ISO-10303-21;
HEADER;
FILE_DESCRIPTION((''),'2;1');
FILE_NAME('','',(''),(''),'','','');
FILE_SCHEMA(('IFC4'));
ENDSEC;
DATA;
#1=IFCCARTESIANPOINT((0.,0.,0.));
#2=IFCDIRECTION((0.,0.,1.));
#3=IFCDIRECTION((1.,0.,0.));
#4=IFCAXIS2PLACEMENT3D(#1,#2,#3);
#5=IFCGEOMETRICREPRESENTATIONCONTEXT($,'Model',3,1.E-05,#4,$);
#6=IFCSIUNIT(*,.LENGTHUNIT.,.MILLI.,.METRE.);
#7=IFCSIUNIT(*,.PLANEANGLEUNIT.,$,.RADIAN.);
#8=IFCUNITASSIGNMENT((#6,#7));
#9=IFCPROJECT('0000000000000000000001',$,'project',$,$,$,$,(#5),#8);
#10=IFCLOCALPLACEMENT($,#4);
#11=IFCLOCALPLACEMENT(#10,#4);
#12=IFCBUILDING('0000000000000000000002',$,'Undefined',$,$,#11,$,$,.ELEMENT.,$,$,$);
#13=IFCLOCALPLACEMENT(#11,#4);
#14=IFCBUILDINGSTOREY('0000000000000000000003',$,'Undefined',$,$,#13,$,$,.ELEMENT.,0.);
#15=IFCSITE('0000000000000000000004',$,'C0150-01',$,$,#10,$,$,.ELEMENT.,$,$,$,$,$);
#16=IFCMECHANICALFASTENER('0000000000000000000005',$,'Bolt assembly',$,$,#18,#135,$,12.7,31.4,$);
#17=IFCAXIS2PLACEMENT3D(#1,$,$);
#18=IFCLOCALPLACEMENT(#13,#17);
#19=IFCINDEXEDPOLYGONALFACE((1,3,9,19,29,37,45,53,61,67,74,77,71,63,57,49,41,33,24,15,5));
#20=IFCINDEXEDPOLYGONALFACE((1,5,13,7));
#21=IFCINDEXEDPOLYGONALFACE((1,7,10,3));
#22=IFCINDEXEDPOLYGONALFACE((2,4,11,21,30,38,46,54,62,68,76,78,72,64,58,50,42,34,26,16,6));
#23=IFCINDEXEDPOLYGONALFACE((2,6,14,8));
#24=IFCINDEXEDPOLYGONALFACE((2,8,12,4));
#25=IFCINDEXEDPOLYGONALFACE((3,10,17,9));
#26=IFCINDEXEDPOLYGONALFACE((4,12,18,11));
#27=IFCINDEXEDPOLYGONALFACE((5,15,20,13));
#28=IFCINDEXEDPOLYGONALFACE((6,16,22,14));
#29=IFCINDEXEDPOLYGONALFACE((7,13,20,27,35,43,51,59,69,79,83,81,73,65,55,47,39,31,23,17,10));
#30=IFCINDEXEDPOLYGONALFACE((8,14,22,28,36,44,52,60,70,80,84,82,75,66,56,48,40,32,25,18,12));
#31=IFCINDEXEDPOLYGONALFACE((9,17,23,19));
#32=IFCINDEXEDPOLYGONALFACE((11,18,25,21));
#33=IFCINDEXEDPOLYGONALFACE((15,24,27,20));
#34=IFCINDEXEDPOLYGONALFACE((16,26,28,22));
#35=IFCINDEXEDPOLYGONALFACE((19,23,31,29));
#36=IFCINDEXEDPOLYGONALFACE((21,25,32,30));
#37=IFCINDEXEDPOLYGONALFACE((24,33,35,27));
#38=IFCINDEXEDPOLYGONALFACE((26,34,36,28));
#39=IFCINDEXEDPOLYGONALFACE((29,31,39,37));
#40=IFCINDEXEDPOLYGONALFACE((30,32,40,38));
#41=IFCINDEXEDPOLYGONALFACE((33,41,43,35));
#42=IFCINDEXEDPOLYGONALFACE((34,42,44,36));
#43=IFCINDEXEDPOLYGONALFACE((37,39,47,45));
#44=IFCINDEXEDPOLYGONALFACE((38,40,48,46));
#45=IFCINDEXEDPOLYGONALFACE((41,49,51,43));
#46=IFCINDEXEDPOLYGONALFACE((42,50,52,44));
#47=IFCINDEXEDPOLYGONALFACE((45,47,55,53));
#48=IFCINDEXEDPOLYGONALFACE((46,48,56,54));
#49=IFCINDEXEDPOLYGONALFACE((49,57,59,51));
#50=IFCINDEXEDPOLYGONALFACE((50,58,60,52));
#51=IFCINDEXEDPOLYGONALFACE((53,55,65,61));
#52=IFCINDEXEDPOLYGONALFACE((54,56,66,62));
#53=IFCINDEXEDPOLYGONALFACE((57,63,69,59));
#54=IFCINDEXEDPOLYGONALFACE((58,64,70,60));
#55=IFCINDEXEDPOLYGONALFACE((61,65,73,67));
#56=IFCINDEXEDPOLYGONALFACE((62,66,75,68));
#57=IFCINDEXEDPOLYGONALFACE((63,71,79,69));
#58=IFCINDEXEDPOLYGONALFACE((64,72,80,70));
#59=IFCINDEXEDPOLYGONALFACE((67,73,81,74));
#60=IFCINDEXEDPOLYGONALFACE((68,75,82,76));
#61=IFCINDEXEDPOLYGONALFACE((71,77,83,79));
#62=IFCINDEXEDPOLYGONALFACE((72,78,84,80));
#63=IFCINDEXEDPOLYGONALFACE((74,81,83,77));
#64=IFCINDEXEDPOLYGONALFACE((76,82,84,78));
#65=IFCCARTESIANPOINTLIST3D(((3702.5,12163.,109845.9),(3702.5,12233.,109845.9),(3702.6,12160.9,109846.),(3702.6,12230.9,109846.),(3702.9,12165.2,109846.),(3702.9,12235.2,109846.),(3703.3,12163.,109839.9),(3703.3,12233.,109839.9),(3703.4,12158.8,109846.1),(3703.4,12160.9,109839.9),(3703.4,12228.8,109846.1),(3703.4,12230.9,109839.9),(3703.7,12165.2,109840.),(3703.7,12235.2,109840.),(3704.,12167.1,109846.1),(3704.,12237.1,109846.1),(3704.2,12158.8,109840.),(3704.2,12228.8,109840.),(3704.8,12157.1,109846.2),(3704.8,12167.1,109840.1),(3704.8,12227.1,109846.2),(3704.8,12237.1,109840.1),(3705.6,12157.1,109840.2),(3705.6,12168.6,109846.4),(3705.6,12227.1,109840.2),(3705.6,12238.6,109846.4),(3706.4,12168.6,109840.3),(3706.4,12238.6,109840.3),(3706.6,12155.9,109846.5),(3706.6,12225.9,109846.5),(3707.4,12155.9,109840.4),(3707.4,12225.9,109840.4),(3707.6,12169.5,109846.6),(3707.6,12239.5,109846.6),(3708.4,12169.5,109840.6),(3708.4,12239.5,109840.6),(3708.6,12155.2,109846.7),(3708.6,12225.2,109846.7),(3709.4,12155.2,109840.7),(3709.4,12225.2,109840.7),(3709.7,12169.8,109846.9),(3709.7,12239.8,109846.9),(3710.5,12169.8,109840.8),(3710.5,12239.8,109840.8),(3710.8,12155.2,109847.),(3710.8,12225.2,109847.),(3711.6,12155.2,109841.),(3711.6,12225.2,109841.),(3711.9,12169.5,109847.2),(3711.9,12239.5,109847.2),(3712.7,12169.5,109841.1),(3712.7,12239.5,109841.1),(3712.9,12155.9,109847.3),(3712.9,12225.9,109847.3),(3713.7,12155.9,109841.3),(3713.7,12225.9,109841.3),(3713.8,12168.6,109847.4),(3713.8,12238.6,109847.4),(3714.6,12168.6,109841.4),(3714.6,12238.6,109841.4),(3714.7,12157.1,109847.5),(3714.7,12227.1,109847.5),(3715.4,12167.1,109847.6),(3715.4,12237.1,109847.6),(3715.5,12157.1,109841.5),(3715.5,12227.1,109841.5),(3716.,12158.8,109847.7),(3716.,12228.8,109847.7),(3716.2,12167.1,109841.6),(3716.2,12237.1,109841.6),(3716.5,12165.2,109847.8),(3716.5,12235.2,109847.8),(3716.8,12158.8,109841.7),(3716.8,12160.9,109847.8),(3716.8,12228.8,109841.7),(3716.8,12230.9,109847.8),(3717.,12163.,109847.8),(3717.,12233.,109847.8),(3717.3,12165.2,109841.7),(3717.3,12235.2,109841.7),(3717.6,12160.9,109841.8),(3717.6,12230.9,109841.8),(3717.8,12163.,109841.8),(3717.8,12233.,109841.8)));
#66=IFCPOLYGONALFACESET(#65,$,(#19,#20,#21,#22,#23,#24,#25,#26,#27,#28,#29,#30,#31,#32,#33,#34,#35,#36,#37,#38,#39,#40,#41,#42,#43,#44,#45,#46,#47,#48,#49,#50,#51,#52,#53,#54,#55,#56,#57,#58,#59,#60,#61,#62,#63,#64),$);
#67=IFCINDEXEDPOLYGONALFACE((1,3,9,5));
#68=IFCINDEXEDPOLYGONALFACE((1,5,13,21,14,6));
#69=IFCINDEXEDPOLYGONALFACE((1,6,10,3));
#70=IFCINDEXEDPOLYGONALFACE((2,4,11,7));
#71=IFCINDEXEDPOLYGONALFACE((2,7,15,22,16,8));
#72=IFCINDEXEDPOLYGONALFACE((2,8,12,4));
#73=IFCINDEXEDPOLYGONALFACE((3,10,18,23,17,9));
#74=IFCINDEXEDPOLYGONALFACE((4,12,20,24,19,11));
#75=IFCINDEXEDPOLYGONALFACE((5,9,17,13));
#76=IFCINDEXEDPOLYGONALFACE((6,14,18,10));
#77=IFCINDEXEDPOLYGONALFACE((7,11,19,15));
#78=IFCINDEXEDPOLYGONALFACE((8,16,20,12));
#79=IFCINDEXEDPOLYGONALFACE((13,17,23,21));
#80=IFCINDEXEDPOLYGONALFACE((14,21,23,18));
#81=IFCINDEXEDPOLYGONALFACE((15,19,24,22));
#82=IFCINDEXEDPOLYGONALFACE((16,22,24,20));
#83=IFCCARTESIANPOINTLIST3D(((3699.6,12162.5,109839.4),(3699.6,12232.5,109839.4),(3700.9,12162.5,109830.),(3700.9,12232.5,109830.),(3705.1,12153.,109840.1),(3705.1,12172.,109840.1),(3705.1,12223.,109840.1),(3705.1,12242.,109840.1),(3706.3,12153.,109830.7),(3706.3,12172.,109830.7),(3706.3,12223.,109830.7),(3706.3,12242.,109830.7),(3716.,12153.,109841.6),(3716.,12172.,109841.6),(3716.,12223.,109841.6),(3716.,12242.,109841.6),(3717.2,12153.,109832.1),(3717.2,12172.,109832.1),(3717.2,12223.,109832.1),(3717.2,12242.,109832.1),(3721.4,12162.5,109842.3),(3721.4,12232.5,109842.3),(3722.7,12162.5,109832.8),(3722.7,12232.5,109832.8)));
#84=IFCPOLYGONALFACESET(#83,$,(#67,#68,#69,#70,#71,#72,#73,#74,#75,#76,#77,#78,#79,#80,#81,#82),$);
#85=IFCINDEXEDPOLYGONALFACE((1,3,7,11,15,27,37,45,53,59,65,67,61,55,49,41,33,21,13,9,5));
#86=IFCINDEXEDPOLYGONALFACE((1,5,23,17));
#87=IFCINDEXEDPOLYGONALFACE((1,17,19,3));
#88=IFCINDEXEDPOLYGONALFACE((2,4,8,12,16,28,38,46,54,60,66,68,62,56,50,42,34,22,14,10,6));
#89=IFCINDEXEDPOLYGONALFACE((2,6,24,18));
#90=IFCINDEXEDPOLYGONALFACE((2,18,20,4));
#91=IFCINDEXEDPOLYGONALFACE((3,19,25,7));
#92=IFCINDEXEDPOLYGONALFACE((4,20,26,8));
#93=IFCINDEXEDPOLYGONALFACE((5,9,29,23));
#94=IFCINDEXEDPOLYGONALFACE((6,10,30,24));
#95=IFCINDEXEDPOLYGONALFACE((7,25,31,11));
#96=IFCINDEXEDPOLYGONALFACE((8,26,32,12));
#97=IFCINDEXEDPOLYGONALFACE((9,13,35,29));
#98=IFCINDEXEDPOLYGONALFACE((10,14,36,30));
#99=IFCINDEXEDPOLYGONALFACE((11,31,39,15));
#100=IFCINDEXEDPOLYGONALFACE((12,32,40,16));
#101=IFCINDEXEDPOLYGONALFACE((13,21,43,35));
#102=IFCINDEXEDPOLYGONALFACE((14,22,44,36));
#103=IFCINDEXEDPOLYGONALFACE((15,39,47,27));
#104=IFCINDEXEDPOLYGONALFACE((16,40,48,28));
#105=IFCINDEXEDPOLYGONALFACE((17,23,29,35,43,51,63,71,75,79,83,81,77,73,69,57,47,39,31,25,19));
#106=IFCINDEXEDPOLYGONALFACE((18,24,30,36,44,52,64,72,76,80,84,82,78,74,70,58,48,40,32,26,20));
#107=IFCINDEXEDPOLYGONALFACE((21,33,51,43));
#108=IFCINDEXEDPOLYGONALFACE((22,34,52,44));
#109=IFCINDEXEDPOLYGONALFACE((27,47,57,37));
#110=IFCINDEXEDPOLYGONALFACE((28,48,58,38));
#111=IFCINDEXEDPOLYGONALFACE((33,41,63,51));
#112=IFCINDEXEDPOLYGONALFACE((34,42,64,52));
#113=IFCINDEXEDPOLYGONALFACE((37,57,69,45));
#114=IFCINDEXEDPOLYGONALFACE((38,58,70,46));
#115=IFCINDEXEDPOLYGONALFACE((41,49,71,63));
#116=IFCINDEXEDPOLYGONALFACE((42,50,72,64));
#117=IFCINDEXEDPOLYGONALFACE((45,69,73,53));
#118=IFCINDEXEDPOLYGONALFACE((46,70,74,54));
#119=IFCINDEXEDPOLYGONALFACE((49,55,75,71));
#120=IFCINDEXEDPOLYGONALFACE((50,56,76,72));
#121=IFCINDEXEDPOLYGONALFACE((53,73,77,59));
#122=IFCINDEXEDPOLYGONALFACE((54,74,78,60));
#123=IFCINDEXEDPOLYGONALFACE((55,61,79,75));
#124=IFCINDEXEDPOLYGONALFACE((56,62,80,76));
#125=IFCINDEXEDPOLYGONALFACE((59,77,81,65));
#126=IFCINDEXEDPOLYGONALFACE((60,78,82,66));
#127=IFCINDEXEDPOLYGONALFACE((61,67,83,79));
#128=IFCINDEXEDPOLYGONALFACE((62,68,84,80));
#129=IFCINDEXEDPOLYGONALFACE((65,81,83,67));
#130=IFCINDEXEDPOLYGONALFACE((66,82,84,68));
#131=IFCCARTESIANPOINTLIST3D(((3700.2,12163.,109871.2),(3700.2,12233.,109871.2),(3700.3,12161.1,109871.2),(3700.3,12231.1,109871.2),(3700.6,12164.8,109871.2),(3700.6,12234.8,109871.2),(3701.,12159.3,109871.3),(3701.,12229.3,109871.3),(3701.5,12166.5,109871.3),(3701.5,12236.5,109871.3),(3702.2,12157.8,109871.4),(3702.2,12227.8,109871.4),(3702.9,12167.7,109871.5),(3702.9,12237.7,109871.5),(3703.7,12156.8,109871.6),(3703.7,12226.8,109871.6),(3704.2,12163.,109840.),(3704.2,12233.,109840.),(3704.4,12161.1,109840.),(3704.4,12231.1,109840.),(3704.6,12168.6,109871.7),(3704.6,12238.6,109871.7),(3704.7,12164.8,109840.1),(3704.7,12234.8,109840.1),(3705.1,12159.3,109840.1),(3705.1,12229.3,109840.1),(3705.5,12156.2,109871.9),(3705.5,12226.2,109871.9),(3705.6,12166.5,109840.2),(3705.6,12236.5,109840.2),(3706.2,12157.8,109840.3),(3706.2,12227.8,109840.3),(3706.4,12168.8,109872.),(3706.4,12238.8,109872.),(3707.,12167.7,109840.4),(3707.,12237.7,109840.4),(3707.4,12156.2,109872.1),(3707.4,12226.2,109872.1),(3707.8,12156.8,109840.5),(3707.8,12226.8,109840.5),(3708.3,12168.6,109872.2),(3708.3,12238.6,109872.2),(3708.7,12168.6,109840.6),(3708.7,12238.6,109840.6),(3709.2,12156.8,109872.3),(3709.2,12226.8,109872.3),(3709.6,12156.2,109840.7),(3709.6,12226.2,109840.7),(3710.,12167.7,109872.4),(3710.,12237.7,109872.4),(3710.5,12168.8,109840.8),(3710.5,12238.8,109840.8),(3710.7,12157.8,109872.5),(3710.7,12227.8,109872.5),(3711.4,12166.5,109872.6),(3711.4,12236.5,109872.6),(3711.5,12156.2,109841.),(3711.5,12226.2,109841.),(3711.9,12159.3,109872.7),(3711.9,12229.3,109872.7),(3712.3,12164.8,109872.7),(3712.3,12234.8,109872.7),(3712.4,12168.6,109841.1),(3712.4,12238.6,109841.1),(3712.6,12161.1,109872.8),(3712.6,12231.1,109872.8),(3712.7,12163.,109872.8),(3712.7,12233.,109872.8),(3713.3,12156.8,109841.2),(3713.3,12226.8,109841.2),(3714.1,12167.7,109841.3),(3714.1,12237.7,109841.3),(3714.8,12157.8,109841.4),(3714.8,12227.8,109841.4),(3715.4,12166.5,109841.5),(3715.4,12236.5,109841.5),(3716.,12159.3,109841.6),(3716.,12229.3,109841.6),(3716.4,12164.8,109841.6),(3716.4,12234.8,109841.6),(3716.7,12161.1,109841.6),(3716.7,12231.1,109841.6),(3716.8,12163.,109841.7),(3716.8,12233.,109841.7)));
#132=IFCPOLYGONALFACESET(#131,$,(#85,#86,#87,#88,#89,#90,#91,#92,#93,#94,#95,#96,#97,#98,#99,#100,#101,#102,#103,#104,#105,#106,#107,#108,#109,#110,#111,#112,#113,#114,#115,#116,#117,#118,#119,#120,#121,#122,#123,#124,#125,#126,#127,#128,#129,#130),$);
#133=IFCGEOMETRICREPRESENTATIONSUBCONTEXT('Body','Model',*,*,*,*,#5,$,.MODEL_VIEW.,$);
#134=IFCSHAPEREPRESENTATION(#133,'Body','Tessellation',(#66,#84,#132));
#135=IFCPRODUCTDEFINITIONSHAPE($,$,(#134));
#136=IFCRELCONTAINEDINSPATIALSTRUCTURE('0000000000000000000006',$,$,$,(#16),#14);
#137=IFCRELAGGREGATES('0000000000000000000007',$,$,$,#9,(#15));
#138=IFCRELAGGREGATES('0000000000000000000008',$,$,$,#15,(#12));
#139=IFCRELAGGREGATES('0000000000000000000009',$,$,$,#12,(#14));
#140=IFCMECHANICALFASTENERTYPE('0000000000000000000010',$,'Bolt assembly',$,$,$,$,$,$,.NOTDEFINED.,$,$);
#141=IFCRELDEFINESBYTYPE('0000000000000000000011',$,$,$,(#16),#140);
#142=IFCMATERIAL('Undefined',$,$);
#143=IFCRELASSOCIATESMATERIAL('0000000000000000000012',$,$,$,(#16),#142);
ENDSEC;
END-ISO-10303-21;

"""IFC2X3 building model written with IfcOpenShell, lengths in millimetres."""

from ifc_helpers import new_model, si_unit, frame, origin_with_axes, origin_2d_with_axis, place, context, subcontext, project, spatial, polyline, circle, outline, extrude, source, transform, mapped, material, type_object, element, save


model = new_model("IFC2X3")

# Units and contexts
model_context = context("Model", 3, precision=1e-05, world=origin_with_axes())
body_context = subcontext(model_context, "Body", "Model", "MODEL_VIEW")
ifc_project = project(units=[si_unit("LENGTHUNIT", "METRE", prefix="MILLI"), si_unit("PLANEANGLEUNIT", "RADIAN")], contexts=[model_context])

# Site, building, storey
site_placement = place(None, origin_with_axes())
site = spatial("IfcSite", under=ifc_project, at=site_placement, Name="C0150-01", CompositionType="ELEMENT")
building_placement = place(site_placement, origin_with_axes())
building = spatial("IfcBuilding", under=site, at=building_placement, Name="Undefined", CompositionType="ELEMENT")
storey_placement = place(building_placement, origin_with_axes())
storey = spatial("IfcBuildingStorey", under=building, at=storey_placement, Name="Undefined", CompositionType="ELEMENT", Elevation=0.0)

# Mechanical fastener
ifc_material_1 = material(Name="Undefined")
mechanical_fastener_type = type_object("IfcMechanicalFastenerType", Name="Bolt assembly")
shared_shape_1 = source(origin_with_axes(), body_context, "Body", "SweptSolid", [
    extrude(circle(Radius=7.3, at=origin_2d_with_axis()), frame((0.0, -2.0, 0.0), z_axis=(0.0, 1.0, 0.0), x_axis=(1.0, 0.0, 0.0)), (0.0, 0.0, 1.0), 6.1),
    extrude(outline(polyline([(9.5, -5.5), (9.5, 5.5), (0.0, 11.0), (-9.5, 5.5), (-9.5, -5.5), (0.0, -11.0), (9.5, -5.5)])), frame((0.0, -11.5, 0.0), z_axis=(0.0, 1.0, 0.0), x_axis=(1.0, 0.0, 0.0)), (0.0, 0.0, 1.0), 9.5),
    extrude(circle(Radius=6.3, at=origin_2d_with_axis()), frame((0.0, -2.0, 0.0), z_axis=(0.0, 1.0, 0.0), x_axis=(1.0, 0.0, 0.0)), (0.0, 0.0, 1.0), 31.4),
])
for number, where, z_axis, x_axis, name in (
    (1, (3710.3, 12162.5, 109842.8), (0.991507, 0.0, 0.130054), (0.0, 1.0, 0.0), "Bolt assembly"),
):
    element("IfcMechanicalFastener", number, at=place(storey_placement, frame(where, z_axis=z_axis, x_axis=x_axis)), inside=storey, type_object=mechanical_fastener_type, material=ifc_material_1, Name=name, NominalDiameter=12.7, NominalLength=31.4, context=body_context, shape_type="MappedRepresentation", body=[
        mapped(shared_shape_1, transform((0.0, 0.0, 0.0))),
        mapped(shared_shape_1, transform((70.0, 0.0, 0.0))),
    ])

save(model, "model.ifc")
